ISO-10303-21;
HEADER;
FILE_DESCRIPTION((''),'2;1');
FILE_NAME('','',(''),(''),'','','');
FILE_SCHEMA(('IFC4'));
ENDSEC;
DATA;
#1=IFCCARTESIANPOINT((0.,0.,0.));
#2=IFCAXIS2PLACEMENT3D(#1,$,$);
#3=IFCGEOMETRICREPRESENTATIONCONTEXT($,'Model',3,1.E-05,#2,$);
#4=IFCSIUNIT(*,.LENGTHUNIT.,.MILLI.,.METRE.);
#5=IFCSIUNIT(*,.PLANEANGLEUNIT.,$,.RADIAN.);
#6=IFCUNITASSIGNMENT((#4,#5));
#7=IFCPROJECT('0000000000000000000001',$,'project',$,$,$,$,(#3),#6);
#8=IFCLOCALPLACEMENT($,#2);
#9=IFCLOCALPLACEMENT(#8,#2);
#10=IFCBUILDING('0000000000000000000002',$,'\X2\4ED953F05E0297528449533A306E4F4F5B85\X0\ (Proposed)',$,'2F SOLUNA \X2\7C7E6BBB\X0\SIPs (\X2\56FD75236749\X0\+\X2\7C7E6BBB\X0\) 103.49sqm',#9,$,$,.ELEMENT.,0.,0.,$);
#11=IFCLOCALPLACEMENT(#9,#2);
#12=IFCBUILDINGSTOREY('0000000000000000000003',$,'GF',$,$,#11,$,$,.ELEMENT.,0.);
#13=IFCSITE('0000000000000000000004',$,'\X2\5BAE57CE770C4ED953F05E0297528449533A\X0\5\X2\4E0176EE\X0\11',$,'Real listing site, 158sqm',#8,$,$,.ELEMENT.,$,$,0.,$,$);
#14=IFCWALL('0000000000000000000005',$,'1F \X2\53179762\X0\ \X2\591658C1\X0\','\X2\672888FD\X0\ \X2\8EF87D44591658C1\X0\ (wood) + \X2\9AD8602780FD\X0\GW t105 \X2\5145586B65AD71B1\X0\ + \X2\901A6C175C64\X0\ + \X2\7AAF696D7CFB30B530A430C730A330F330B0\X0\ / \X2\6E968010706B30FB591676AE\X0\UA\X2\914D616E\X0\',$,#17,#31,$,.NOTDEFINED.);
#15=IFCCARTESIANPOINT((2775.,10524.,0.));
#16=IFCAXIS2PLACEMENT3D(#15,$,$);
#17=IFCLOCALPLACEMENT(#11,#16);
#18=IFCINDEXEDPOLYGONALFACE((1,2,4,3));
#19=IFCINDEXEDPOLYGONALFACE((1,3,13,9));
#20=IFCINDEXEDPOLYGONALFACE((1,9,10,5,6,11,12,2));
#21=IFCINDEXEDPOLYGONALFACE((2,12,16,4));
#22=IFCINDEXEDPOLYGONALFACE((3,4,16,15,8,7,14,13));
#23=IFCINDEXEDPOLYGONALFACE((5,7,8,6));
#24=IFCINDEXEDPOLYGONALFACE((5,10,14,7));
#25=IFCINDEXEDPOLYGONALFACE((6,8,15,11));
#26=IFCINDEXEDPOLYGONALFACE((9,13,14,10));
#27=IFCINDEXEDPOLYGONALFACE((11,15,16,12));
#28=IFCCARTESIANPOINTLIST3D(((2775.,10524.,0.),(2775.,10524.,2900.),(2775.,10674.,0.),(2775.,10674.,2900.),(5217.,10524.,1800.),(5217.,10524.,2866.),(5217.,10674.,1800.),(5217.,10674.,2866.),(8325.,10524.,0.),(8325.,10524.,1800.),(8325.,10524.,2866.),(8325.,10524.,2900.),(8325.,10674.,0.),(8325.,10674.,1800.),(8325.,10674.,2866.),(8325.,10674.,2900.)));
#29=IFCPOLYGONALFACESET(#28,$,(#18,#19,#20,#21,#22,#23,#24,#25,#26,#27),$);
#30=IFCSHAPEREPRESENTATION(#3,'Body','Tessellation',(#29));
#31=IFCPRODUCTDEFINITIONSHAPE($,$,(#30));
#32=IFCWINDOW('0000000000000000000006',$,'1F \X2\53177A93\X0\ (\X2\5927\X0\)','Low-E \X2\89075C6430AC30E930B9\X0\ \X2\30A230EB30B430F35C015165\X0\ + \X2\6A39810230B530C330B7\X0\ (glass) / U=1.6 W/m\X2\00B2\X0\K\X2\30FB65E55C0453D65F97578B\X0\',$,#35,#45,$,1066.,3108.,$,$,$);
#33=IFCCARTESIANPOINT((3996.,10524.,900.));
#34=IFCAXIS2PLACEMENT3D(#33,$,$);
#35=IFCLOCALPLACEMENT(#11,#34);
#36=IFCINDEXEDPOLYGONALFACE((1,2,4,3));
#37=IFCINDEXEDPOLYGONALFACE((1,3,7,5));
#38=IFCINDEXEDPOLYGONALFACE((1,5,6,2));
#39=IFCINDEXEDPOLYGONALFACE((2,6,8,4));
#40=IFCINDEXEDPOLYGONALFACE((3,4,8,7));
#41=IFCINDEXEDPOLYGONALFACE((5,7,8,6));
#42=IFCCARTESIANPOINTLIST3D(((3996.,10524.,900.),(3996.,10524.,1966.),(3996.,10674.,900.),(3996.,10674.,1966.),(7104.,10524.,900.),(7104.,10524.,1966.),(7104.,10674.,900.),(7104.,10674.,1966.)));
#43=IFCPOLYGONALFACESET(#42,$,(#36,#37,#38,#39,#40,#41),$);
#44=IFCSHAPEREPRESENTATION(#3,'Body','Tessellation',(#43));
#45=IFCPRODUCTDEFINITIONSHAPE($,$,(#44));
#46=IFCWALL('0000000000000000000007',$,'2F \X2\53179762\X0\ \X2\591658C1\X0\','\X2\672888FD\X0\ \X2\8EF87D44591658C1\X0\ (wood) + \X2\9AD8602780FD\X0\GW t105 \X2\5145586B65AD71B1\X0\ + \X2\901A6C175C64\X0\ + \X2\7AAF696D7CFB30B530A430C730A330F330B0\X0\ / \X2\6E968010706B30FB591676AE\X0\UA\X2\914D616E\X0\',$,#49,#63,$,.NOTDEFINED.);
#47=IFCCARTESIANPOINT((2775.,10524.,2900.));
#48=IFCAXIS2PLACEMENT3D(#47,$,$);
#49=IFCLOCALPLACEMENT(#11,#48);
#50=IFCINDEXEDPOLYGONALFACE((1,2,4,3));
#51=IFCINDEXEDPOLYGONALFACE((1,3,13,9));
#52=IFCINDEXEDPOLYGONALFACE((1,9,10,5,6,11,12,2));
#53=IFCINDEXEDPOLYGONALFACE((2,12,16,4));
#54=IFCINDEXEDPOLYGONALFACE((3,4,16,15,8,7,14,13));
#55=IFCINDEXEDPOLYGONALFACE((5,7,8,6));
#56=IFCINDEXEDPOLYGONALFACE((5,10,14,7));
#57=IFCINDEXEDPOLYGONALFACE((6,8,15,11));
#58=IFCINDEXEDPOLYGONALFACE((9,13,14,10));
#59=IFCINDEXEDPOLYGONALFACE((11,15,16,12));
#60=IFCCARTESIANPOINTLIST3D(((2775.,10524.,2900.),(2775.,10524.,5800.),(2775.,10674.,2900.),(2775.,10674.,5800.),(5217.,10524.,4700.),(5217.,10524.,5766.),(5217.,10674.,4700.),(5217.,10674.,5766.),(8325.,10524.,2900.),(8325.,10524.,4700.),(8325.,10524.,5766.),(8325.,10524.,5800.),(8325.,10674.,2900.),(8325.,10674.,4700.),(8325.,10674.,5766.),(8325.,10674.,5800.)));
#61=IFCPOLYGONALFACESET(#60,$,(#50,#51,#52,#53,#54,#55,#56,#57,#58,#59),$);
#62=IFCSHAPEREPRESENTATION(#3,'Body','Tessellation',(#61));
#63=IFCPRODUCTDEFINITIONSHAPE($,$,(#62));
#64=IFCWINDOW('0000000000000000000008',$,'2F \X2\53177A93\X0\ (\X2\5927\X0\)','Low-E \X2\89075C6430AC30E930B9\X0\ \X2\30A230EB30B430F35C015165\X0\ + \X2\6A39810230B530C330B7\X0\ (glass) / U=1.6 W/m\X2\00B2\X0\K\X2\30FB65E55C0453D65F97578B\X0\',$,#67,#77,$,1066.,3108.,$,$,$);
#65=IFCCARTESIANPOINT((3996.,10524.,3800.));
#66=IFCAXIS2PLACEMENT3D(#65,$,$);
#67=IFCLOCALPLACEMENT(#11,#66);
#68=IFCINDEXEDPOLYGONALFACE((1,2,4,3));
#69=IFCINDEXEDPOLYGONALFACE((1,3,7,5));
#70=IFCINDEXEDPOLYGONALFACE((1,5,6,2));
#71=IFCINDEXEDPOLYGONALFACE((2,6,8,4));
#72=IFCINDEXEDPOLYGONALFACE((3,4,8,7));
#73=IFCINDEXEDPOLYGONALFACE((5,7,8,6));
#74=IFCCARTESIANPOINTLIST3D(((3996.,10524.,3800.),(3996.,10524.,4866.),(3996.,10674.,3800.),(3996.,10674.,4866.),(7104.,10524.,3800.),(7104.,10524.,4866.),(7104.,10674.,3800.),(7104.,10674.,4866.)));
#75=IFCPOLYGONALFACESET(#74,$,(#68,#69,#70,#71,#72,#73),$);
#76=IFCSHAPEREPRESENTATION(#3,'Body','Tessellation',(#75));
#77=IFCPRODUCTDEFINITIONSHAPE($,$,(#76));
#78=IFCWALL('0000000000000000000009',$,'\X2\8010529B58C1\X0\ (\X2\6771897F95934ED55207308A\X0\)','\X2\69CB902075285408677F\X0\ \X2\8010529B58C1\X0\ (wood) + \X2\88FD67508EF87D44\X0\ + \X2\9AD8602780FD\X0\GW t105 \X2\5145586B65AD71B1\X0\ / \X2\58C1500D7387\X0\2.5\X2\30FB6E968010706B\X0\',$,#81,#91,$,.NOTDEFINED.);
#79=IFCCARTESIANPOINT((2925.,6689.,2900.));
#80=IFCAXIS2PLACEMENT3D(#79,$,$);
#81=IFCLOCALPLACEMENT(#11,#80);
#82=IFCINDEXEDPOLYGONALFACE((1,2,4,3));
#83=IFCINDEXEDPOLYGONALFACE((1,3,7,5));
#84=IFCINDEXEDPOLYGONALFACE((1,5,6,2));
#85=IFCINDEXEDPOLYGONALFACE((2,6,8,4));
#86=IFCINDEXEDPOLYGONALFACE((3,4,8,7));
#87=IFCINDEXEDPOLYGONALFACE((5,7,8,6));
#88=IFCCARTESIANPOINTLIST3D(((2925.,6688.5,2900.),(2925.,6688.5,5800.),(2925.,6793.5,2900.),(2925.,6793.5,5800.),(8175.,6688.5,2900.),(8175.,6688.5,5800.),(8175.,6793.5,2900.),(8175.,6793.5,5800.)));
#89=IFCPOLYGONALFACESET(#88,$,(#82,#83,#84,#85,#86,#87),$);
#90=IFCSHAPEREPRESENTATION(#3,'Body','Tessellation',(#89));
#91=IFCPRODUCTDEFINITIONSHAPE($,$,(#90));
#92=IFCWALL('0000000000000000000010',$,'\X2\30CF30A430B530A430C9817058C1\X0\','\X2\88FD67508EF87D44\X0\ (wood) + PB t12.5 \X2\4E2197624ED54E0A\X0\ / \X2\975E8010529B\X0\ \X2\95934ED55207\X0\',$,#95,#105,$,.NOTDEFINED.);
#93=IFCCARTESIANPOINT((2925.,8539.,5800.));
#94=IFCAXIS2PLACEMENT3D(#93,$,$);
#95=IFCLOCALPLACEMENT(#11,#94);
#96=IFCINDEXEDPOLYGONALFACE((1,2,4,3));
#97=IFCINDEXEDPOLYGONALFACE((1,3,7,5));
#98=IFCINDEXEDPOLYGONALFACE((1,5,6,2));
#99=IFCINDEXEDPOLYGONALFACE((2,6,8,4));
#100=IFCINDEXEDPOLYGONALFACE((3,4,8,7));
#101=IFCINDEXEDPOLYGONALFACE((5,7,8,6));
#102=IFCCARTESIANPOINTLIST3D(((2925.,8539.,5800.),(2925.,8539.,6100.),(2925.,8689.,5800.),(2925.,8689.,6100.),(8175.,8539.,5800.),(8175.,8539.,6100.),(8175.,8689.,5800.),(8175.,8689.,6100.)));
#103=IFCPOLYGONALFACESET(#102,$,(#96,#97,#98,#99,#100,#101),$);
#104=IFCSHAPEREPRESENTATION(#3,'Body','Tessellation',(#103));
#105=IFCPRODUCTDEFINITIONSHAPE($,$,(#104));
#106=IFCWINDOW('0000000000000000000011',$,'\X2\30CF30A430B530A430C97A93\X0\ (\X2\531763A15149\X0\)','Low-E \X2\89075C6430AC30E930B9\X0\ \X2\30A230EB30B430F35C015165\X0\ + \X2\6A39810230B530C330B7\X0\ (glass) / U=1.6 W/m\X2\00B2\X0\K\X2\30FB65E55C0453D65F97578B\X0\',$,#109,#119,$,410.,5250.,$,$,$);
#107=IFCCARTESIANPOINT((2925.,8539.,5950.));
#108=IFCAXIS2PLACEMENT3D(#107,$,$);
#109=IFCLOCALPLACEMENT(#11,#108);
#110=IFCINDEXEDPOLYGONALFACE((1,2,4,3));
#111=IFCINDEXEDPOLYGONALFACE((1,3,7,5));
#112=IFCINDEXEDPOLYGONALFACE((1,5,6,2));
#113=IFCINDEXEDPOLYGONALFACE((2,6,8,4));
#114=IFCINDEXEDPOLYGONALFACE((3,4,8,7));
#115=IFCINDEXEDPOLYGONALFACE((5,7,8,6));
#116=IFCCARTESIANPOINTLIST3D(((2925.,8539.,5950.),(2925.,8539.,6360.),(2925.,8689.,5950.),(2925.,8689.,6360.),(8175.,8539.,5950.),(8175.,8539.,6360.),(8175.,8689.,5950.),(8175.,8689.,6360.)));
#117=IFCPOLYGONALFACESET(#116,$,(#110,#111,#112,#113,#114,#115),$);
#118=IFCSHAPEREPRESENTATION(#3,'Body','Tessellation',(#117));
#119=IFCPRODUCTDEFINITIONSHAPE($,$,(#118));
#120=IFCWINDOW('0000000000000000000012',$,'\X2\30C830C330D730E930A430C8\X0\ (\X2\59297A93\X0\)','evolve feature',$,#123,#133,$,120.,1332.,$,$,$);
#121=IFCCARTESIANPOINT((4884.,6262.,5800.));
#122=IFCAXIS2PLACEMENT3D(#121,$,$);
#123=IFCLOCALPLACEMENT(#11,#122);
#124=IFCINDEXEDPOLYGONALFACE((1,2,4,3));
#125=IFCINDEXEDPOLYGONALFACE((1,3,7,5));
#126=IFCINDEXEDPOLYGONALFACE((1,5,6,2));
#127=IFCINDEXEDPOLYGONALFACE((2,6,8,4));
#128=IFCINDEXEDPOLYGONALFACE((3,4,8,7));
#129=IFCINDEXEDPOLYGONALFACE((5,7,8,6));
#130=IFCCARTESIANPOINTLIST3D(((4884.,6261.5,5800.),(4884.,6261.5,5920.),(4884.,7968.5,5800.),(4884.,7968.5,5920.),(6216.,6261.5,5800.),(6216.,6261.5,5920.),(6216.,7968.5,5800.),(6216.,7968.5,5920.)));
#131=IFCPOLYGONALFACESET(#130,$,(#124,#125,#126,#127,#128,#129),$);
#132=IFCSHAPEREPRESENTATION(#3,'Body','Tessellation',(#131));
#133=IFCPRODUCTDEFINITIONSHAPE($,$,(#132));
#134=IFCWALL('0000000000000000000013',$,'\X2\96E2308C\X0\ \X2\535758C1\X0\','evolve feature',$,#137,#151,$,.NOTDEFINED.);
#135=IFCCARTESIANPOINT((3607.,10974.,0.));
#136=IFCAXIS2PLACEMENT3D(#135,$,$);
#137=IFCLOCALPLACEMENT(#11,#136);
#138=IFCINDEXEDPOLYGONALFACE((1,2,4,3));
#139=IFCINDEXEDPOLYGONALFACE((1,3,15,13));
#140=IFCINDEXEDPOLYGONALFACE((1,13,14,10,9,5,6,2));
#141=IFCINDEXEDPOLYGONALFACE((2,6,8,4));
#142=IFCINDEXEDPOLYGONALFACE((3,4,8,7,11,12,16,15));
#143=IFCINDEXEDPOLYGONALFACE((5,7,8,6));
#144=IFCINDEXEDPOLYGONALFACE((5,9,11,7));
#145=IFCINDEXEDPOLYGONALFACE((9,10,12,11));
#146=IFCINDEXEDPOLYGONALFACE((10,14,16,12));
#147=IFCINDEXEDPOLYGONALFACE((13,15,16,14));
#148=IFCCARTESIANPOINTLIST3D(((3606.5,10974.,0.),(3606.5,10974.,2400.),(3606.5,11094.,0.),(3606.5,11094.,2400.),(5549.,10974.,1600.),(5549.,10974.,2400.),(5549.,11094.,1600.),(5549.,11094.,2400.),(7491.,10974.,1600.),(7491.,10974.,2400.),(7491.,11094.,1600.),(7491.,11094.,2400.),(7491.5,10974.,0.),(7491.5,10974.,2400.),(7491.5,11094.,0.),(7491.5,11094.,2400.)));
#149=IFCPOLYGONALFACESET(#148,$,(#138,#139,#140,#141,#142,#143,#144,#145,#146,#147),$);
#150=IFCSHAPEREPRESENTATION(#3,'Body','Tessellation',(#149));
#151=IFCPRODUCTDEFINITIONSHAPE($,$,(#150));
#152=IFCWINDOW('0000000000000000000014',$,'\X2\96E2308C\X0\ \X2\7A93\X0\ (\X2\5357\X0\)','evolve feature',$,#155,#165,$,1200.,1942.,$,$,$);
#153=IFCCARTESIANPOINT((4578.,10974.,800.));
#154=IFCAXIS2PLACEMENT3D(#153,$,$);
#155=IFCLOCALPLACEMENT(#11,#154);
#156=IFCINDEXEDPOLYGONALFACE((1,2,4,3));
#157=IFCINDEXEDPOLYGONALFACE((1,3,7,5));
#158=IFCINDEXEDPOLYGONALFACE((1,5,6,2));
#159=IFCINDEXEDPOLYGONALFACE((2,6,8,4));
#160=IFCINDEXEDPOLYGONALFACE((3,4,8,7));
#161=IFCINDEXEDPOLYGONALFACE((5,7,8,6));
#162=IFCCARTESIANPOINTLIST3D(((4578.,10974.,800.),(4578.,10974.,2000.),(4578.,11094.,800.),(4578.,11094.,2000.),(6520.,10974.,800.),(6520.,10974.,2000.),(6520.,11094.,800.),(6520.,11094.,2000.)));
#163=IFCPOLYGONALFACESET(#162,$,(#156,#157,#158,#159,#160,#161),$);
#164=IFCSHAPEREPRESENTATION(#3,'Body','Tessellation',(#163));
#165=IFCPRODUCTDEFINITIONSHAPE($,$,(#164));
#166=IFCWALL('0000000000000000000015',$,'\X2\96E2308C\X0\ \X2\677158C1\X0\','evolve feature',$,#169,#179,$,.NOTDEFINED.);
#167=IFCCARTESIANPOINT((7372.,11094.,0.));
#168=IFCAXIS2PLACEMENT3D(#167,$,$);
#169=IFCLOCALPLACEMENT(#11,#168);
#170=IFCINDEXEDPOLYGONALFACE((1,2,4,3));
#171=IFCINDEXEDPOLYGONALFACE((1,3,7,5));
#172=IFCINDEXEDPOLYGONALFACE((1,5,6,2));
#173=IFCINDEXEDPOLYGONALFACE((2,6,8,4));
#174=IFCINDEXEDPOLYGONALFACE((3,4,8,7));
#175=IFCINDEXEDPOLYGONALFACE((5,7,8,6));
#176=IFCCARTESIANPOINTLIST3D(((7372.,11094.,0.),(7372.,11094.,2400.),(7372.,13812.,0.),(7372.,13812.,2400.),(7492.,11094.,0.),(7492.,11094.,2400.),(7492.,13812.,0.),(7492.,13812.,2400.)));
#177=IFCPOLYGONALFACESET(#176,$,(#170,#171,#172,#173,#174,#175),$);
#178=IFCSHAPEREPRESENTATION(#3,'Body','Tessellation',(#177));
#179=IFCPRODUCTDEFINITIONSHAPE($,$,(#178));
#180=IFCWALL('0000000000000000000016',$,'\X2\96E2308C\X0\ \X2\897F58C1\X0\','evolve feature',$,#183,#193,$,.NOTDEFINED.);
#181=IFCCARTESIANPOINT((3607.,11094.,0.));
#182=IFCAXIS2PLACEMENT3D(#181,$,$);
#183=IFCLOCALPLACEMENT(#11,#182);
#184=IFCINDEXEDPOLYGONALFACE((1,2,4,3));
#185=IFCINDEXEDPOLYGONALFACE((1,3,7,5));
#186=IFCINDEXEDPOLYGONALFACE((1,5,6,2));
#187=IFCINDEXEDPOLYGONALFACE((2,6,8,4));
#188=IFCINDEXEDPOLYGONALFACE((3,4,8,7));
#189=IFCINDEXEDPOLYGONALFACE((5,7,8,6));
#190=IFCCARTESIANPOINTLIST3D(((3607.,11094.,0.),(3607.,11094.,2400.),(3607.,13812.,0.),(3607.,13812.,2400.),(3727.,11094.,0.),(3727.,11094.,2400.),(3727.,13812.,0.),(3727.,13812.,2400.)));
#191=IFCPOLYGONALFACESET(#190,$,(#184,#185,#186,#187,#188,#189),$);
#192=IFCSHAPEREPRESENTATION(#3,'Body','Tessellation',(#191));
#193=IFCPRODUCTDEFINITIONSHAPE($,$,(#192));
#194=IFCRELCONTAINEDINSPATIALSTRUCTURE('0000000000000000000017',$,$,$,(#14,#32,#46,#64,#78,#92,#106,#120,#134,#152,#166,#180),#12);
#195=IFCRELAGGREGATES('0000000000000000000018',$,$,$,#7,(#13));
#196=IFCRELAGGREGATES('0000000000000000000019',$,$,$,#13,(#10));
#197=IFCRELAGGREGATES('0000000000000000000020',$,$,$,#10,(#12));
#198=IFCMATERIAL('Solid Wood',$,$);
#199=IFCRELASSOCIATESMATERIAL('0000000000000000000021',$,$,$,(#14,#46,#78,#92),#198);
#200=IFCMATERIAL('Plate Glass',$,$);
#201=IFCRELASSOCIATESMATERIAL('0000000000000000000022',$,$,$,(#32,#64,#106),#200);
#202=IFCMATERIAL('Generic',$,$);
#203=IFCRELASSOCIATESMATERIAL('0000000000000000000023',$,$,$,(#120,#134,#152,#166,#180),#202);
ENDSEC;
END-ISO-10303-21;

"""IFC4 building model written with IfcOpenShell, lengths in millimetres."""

from ifc_helpers import new_model, si_unit, frame, frame_2d, origin, place, context, project, spatial, rectangle, extrude, material, element, fill, save


model = new_model("IFC4")

# Units and contexts
model_context = context("Model", 3, precision=1e-05, world=origin())
ifc_project = project(units=[si_unit("LENGTHUNIT", "METRE", prefix="MILLI"), si_unit("PLANEANGLEUNIT", "RADIAN")], contexts=[model_context])

# Site, building, storey
site_placement = place(None, origin())
site = spatial("IfcSite", under=ifc_project, at=site_placement, Name="宮城県仙台市青葉区5丁目11", ObjectType="Real listing site, 158sqm", CompositionType="ELEMENT", RefElevation=0.0)
building_placement = place(site_placement, origin())
building = spatial("IfcBuilding", under=site, at=building_placement, Name="仙台市青葉区の住宅 (Proposed)", ObjectType="2F SOLUNA 籾殻SIPs (国産杉+籾殻) 103.49sqm", CompositionType="ELEMENT", ElevationOfRefHeight=0.0, ElevationOfTerrain=0.0)
storey_placement = place(building_placement, origin())
storey = spatial("IfcBuildingStorey", under=building, at=storey_placement, Name="GF", CompositionType="ELEMENT", Elevation=0.0)

# Shared definitions
ifc_material_1 = material(Name="Generic")

# Wall, opening, window
ifc_material_2 = material(Name="Solid Wood")
wall_1_placement = place(storey_placement, frame((2775.0, 10524.0, 0.0)))
wall_1 = element("IfcWall", 1, at=wall_1_placement, inside=storey, material=ifc_material_2, Name="1F 北面 外壁", Description="木製 軸組外壁 (wood) + 高性能GW t105 充填断熱 + 通気層 + 窯業系サイディング / 準耐火・外皮UA配慮", PredefinedType="NOTDEFINED", context=model_context, shape_type="SweptSolid", body=[
    extrude(rectangle(XDim=5550.0, YDim=150.0, at=frame_2d((2775.0, 75.0))), frame((2775.0, 10524.0, 0.0)), (0.0, 0.0, 1.0), 2900.0),
])
opening_1_placement = place(storey_placement, frame((3996.0, 10524.0, 900.0)))
opening_1 = element("IfcOpeningElement", 2, at=opening_1_placement, cuts=wall_1, PredefinedType="NOTDEFINED", context=model_context, shape_type="SweptSolid", body=[
    extrude(rectangle(XDim=3108.0, YDim=150.0, at=frame_2d((1554.0, 75.0))), frame((3996.0, 10524.0, 900.0)), (0.0, 0.0, 1.0), 1066.0),
])
ifc_material_3 = material(Name="Plate Glass")
window_1_placement = place(storey_placement, frame((3996.0, 10524.0, 900.0)))
window_1 = element("IfcWindow", 3, at=window_1_placement, inside=storey, material=ifc_material_3, Name="1F 北窓 (大)", Description="Low-E 複層ガラス アルゴン封入 + 樹脂サッシ (glass) / U=1.6 W/m²K・日射取得型", OverallHeight=1066.0, OverallWidth=3108.0, context=model_context, shape_type="SweptSolid", body=[
    extrude(rectangle(XDim=3108.0, YDim=150.0, at=frame_2d((1554.0, 75.0))), frame((3996.0, 10524.0, 900.0)), (0.0, 0.0, 1.0), 1066.0),
])
fill(opening_1, window_1)

# Wall, opening, window
wall_2_placement = place(storey_placement, frame((2775.0, 10524.0, 2900.0)))
wall_2 = element("IfcWall", 4, at=wall_2_placement, inside=storey, material=ifc_material_2, Name="2F 北面 外壁", Description="木製 軸組外壁 (wood) + 高性能GW t105 充填断熱 + 通気層 + 窯業系サイディング / 準耐火・外皮UA配慮", PredefinedType="NOTDEFINED", context=model_context, shape_type="SweptSolid", body=[
    extrude(rectangle(XDim=5550.0, YDim=150.0, at=frame_2d((2775.0, 75.0))), frame((2775.0, 10524.0, 2900.0)), (0.0, 0.0, 1.0), 2900.0),
])
opening_2_placement = place(storey_placement, frame((3996.0, 10524.0, 3800.0)))
opening_2 = element("IfcOpeningElement", 5, at=opening_2_placement, cuts=wall_2, PredefinedType="NOTDEFINED", context=model_context, shape_type="SweptSolid", body=[
    extrude(rectangle(XDim=3108.0, YDim=150.0, at=frame_2d((1554.0, 75.0))), frame((3996.0, 10524.0, 3800.0)), (0.0, 0.0, 1.0), 1066.0),
])
window_2_placement = place(storey_placement, frame((3996.0, 10524.0, 3800.0)))
window_2 = element("IfcWindow", 6, at=window_2_placement, inside=storey, material=ifc_material_3, Name="2F 北窓 (大)", Description="Low-E 複層ガラス アルゴン封入 + 樹脂サッシ (glass) / U=1.6 W/m²K・日射取得型", OverallHeight=1066.0, OverallWidth=3108.0, context=model_context, shape_type="SweptSolid", body=[
    extrude(rectangle(XDim=3108.0, YDim=150.0, at=frame_2d((1554.0, 75.0))), frame((3996.0, 10524.0, 3800.0)), (0.0, 0.0, 1.0), 1066.0),
])
fill(opening_2, window_2)

# Wall
wall_3_placement = place(storey_placement, frame((2925.0, 6689.0, 2900.0)))
element("IfcWall", 7, at=wall_3_placement, inside=storey, material=ifc_material_2, Name="耐力壁 (東西間仕切り)", Description="構造用合板 耐力壁 (wood) + 製材軸組 + 高性能GW t105 充填断熱 / 壁倍率2.5・準耐火", PredefinedType="NOTDEFINED", context=model_context, shape_type="SweptSolid", body=[
    extrude(rectangle(XDim=5250.0, YDim=105.0, at=frame_2d((2625.0, 52.0))), frame((2925.0, 6689.0, 2900.0)), (0.0, 0.0, 1.0), 2900.0),
])

# Wall, opening, window
wall_4_placement = place(storey_placement, frame((2925.0, 8539.0, 5800.0)))
wall_4 = element("IfcWall", 8, at=wall_4_placement, inside=storey, material=ifc_material_2, Name="ハイサイド腰壁", Description="製材軸組 (wood) + PB t12.5 両面仕上 / 非耐力 間仕切", PredefinedType="NOTDEFINED", context=model_context, shape_type="SweptSolid", body=[
    extrude(rectangle(XDim=5250.0, YDim=150.0, at=frame_2d((2625.0, 75.0))), frame((2925.0, 8539.0, 5800.0)), (0.0, 0.0, 1.0), 700.0),
])
opening_3_placement = place(storey_placement, frame((2925.0, 8539.0, 5950.0)))
opening_3 = element("IfcOpeningElement", 9, at=opening_3_placement, cuts=wall_4, PredefinedType="NOTDEFINED", context=model_context, shape_type="SweptSolid", body=[
    extrude(rectangle(XDim=5250.0, YDim=150.0, at=frame_2d((2625.0, 75.0))), frame((2925.0, 8539.0, 5950.0)), (0.0, 0.0, 1.0), 410.0),
])
window_3_placement = place(storey_placement, frame((2925.0, 8539.0, 5950.0)))
window_3 = element("IfcWindow", 10, at=window_3_placement, inside=storey, material=ifc_material_3, Name="ハイサイド窓 (北採光)", Description="Low-E 複層ガラス アルゴン封入 + 樹脂サッシ (glass) / U=1.6 W/m²K・日射取得型", OverallHeight=410.0, OverallWidth=5250.0, context=model_context, shape_type="SweptSolid", body=[
    extrude(rectangle(XDim=5250.0, YDim=150.0, at=frame_2d((2625.0, 75.0))), frame((2925.0, 8539.0, 5950.0)), (0.0, 0.0, 1.0), 410.0),
])
fill(opening_3, window_3)

# Window
window_4_placement = place(storey_placement, frame((4884.0, 6262.0, 5800.0)))
element("IfcWindow", 11, at=window_4_placement, inside=storey, material=ifc_material_1, Name="トップライト (天窓)", Description="evolve feature", OverallHeight=120.0, OverallWidth=1332.0, context=model_context, shape_type="SweptSolid", body=[
    extrude(rectangle(XDim=1332.0, YDim=1707.0, at=frame_2d((666.0, 853.0))), frame((4884.0, 6262.0, 5800.0)), (0.0, 0.0, 1.0), 120.0),
])

# Wall, opening, window
wall_5_placement = place(storey_placement, frame((3607.0, 10974.0, 0.0)))
wall_5 = element("IfcWall", 12, at=wall_5_placement, inside=storey, material=ifc_material_1, Name="離れ 南壁", Description="evolve feature", PredefinedType="NOTDEFINED", context=model_context, shape_type="SweptSolid", body=[
    extrude(rectangle(XDim=3885.0, YDim=120.0, at=frame_2d((1942.0, 60.0))), frame((3607.0, 10974.0, 0.0)), (0.0, 0.0, 1.0), 2400.0),
])
opening_4_placement = place(storey_placement, frame((4578.0, 10974.0, 800.0)))
opening_4 = element("IfcOpeningElement", 13, at=opening_4_placement, cuts=wall_5, PredefinedType="NOTDEFINED", context=model_context, shape_type="SweptSolid", body=[
    extrude(rectangle(XDim=1942.0, YDim=120.0, at=frame_2d((971.0, 60.0))), frame((4578.0, 10974.0, 800.0)), (0.0, 0.0, 1.0), 1200.0),
])
window_5_placement = place(storey_placement, frame((4578.0, 10974.0, 800.0)))
window_5 = element("IfcWindow", 14, at=window_5_placement, inside=storey, material=ifc_material_1, Name="離れ 窓 (南)", Description="evolve feature", OverallHeight=1200.0, OverallWidth=1942.0, context=model_context, shape_type="SweptSolid", body=[
    extrude(rectangle(XDim=1942.0, YDim=120.0, at=frame_2d((971.0, 60.0))), frame((4578.0, 10974.0, 800.0)), (0.0, 0.0, 1.0), 1200.0),
])
fill(opening_4, window_5)

# Walls
wall_6_placement = place(storey_placement, frame((7372.0, 11094.0, 0.0)))
element("IfcWall", 15, at=wall_6_placement, inside=storey, material=ifc_material_1, Name="離れ 東壁", Description="evolve feature", PredefinedType="NOTDEFINED", context=model_context, shape_type="SweptSolid", body=[
    extrude(rectangle(XDim=120.0, YDim=2718.0, at=frame_2d((60.0, 1359.0))), frame((7372.0, 11094.0, 0.0)), (0.0, 0.0, 1.0), 2400.0),
])
wall_7_placement = place(storey_placement, frame((3607.0, 11094.0, 0.0)))
element("IfcWall", 16, at=wall_7_placement, inside=storey, material=ifc_material_1, Name="離れ 西壁", Description="evolve feature", PredefinedType="NOTDEFINED", context=model_context, shape_type="SweptSolid", body=[
    extrude(rectangle(XDim=120.0, YDim=2718.0, at=frame_2d((60.0, 1359.0))), frame((3607.0, 11094.0, 0.0)), (0.0, 0.0, 1.0), 2400.0),
])

save(model, "model.ifc")
